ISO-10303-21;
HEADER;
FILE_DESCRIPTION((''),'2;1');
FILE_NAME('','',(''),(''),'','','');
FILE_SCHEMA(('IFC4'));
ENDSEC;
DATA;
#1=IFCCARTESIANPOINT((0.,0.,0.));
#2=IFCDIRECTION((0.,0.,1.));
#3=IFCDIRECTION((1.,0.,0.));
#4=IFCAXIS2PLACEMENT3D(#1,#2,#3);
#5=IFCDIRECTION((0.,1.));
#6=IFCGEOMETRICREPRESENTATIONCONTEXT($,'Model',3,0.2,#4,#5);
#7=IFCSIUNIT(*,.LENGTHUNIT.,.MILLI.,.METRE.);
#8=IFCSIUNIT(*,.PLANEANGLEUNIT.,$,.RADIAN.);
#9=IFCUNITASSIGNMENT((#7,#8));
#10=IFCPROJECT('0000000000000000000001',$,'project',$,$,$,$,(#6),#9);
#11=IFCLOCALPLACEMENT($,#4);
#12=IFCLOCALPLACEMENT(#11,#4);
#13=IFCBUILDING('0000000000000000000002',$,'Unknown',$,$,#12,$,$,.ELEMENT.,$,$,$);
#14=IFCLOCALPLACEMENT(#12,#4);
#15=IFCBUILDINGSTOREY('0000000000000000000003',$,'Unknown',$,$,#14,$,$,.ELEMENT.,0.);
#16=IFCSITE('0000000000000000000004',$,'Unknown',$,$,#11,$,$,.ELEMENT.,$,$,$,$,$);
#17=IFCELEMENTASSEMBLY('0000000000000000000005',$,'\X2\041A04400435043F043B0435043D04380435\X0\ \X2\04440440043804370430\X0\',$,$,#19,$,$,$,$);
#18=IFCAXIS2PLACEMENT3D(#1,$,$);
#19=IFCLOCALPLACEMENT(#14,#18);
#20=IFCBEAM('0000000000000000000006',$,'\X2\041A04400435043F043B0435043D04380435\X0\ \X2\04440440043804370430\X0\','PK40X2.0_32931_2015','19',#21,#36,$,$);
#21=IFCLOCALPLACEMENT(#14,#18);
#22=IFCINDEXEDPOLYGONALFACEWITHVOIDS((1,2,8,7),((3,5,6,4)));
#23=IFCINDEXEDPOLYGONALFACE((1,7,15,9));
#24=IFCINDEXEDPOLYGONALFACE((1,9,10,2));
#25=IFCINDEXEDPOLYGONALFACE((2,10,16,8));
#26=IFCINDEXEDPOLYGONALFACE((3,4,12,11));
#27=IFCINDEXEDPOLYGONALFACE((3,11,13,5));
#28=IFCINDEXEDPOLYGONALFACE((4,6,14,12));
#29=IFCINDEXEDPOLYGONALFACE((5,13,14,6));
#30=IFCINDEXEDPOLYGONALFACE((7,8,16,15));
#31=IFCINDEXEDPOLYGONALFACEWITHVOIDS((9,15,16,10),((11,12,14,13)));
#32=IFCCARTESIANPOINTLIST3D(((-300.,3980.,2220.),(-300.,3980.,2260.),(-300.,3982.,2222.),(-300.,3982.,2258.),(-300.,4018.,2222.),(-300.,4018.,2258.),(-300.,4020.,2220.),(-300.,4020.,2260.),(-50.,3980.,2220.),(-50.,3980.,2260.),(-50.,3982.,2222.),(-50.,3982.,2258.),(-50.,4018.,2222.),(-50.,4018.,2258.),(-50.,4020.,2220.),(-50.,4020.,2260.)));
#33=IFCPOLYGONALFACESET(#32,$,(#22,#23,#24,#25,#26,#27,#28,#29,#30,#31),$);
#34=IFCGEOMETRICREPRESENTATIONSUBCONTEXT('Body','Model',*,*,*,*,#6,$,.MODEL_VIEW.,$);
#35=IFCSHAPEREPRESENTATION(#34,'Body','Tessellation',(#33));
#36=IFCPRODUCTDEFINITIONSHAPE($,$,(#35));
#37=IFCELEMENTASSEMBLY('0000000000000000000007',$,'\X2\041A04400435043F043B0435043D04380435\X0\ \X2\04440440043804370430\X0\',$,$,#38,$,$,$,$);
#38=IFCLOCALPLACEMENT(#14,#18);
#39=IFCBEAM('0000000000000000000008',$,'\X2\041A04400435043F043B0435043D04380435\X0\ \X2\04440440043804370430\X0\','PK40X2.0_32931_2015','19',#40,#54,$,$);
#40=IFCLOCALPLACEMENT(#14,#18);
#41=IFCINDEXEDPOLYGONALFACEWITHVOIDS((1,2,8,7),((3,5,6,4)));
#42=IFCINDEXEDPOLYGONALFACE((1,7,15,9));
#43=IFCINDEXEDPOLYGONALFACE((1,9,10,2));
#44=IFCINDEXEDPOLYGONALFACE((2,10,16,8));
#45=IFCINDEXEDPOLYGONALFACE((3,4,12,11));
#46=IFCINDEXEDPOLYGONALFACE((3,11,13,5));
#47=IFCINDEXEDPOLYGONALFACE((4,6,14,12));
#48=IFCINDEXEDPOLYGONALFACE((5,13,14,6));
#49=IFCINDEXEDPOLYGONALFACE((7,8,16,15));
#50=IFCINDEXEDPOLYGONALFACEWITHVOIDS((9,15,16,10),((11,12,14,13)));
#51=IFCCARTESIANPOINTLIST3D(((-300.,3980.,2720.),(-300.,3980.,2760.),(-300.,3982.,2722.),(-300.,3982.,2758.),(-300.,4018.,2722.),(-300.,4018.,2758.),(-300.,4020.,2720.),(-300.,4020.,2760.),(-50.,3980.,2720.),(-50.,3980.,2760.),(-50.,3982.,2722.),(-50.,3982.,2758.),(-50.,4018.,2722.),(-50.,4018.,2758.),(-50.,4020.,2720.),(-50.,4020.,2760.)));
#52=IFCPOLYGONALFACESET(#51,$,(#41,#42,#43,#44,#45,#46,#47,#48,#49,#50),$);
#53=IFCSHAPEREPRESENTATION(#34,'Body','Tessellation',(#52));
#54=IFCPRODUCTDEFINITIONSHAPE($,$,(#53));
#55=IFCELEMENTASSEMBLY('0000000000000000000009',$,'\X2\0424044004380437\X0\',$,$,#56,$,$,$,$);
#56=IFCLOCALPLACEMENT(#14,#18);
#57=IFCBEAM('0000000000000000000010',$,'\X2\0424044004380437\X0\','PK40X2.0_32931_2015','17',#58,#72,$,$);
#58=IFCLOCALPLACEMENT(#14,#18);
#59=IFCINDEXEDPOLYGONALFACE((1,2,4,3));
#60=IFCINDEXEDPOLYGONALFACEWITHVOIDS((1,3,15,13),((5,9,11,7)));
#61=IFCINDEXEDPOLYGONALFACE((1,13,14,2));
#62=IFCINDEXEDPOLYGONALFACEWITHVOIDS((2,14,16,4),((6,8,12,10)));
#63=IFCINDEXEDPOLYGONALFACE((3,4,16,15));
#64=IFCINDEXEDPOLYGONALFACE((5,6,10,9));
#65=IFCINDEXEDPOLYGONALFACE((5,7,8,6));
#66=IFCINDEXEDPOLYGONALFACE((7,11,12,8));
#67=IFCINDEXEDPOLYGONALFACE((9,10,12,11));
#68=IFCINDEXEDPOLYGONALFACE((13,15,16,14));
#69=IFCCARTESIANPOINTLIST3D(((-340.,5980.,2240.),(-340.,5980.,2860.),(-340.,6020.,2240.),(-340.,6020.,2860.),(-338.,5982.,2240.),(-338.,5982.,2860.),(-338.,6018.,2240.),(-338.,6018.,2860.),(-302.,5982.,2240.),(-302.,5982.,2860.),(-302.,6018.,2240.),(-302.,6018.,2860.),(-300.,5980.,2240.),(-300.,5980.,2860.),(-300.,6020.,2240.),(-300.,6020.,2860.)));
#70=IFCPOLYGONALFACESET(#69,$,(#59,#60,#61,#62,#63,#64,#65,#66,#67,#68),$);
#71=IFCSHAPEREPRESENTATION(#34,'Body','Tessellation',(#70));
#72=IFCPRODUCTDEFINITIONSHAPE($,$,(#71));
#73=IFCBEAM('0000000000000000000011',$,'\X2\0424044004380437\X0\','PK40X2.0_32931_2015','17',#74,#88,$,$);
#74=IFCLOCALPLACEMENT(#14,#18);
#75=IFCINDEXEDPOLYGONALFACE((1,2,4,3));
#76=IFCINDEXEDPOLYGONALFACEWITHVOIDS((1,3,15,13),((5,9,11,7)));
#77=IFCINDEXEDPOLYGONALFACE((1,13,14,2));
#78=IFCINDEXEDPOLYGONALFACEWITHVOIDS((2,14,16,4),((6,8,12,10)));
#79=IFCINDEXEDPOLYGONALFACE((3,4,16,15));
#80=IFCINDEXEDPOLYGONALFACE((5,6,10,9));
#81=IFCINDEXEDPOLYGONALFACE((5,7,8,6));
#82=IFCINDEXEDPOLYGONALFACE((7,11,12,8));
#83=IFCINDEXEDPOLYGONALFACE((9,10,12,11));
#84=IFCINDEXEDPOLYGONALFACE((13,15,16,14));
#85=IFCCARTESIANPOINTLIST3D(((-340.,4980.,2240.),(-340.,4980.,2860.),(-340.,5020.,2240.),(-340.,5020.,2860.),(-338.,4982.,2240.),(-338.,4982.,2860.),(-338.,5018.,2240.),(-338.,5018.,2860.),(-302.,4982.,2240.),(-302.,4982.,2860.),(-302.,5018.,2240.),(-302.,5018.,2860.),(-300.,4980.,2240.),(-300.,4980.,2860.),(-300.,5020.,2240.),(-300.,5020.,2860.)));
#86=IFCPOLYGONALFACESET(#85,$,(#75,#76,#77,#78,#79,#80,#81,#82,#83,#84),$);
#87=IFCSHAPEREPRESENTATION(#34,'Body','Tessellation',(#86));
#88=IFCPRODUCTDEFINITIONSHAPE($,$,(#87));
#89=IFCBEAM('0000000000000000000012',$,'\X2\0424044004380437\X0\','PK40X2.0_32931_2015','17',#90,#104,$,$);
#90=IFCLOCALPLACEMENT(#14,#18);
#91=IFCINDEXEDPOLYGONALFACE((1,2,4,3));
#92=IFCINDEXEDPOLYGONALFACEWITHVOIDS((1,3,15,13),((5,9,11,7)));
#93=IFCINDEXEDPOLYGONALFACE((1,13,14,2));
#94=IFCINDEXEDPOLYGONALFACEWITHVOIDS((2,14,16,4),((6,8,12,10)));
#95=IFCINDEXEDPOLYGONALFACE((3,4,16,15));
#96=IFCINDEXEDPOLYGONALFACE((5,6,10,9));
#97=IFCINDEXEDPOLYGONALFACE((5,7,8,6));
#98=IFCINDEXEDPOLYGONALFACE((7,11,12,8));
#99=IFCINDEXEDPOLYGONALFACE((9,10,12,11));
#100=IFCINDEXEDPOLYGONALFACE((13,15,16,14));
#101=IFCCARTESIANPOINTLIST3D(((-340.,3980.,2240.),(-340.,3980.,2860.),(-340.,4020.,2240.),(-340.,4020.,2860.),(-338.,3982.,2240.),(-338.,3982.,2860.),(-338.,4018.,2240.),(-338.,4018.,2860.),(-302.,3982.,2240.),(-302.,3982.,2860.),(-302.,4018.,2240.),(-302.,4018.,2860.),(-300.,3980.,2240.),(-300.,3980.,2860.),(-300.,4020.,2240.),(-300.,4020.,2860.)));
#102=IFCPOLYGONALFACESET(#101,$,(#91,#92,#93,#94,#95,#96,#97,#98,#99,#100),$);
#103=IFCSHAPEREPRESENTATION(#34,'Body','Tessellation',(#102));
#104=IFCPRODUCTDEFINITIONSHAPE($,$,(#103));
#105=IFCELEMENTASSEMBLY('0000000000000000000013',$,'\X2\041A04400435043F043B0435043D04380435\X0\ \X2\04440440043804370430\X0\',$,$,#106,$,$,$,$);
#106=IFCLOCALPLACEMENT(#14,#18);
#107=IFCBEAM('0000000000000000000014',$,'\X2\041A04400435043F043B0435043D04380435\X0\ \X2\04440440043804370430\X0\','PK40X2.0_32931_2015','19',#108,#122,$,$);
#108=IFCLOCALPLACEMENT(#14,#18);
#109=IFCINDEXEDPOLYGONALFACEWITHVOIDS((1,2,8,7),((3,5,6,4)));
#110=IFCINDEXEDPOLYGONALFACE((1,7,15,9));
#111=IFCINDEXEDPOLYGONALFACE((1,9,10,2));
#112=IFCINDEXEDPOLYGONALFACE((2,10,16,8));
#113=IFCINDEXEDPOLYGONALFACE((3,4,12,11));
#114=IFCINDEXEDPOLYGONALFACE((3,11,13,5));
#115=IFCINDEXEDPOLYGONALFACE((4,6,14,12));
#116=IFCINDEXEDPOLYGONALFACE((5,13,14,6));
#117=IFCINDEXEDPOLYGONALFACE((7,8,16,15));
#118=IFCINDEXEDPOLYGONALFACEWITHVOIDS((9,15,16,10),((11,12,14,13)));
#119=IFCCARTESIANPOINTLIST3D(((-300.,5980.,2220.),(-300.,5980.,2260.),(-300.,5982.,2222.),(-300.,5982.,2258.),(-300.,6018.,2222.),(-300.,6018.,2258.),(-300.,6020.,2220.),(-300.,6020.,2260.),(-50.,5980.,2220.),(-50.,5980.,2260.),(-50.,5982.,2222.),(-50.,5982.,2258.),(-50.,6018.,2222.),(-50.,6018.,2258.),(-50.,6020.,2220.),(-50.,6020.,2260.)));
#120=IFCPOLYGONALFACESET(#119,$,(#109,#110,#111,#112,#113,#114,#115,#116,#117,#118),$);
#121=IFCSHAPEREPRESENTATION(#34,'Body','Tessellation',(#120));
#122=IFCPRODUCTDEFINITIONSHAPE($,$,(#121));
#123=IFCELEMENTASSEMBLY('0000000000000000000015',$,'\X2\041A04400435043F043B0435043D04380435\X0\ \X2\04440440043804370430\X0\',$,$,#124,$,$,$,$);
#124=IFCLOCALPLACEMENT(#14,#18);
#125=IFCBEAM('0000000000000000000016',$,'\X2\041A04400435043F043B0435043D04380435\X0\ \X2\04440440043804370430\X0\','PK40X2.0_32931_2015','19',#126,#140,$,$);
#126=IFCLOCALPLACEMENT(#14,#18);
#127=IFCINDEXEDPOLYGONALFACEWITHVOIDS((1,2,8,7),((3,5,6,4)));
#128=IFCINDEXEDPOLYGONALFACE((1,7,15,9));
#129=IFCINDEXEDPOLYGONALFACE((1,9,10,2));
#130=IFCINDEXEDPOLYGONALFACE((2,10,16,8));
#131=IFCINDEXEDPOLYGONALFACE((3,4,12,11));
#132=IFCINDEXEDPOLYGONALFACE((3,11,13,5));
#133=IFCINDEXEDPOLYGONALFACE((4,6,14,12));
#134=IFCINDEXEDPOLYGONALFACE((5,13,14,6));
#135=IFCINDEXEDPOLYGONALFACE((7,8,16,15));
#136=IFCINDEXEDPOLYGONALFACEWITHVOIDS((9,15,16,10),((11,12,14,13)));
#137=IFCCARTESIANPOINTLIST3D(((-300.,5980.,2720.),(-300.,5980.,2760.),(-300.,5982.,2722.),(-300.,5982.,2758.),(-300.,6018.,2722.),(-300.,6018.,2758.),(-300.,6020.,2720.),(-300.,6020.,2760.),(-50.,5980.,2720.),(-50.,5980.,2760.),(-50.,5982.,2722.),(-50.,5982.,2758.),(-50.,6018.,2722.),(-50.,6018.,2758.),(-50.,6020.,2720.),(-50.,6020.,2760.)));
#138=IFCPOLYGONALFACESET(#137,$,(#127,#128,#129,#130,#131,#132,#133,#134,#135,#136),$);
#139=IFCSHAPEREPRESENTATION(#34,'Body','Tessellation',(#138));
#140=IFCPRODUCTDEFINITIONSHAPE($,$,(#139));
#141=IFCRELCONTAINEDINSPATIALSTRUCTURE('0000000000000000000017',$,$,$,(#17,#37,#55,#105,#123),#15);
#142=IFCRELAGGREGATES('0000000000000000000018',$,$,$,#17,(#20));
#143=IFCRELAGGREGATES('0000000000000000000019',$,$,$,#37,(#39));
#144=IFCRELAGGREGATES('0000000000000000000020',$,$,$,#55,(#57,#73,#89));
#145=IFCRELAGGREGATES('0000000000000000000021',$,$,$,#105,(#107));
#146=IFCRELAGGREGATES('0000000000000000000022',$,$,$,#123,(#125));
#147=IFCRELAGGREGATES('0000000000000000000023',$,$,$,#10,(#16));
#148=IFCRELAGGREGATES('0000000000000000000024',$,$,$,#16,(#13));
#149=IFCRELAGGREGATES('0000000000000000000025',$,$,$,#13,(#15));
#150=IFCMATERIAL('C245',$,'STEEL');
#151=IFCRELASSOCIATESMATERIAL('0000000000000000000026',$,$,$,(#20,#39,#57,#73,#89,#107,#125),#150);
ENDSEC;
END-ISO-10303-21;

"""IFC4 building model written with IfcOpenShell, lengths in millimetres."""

from ifc_helpers import new_model, si_unit, direction, frame, origin_with_axes, place, context, subcontext, project, spatial, line, indexed_curve, outline, extrude, material, element, aggregate, save


model = new_model("IFC4")

# Units and contexts
model_context = context("Model", 3, precision=0.2, world=origin_with_axes(), true_north=direction((0.0, 1.0)))
body_context = subcontext(model_context, "Body", "Model", "MODEL_VIEW")
ifc_project = project(units=[si_unit("LENGTHUNIT", "METRE", prefix="MILLI"), si_unit("PLANEANGLEUNIT", "RADIAN")], contexts=[model_context])

# Site, building, storey
site_placement = place(None, origin_with_axes())
site = spatial("IfcSite", under=ifc_project, at=site_placement, Name="Unknown", CompositionType="ELEMENT")
building_placement = place(site_placement, origin_with_axes())
building = spatial("IfcBuilding", under=site, at=building_placement, Name="Unknown", CompositionType="ELEMENT")
storey_placement = place(building_placement, origin_with_axes())
storey = spatial("IfcBuildingStorey", under=building, at=storey_placement, Name="Unknown", CompositionType="ELEMENT", Elevation=0.0)

# Shared definitions
ifc_material_1 = material(Name="C245", Category="STEEL")

# Element assemblies, beams
assembly_1_placement = place(storey_placement, frame((-300.0, 4000.0, 2240.0), z_axis=(0.0, 1.0, 0.0), x_axis=(1.0, 0.0, 0.0)))
assembly_1 = element("IfcElementAssembly", 1, at=assembly_1_placement, inside=storey, Name="Крепление фриза")
beam_1_placement = place(assembly_1_placement, origin_with_axes())
beam_1 = element("IfcBeam", 2, at=beam_1_placement, material=ifc_material_1, Name="Крепление фриза", Description="PK40X2.0_32931_2015", ObjectType="19", context=body_context, shape_type="SolidModel", body=[
    extrude(outline(indexed_curve([(-20.0, -20.0), (20.0, -20.0), (20.0, 20.0), (-20.0, 20.0)], segments=[line(1, 2, 3, 4, 1)]), holes=[indexed_curve([(-18.0, -18.0), (-18.0, 18.0), (18.0, 18.0), (18.0, -18.0)], segments=[line(1, 2, 3, 4, 1)])]), frame((0.0, 0.0, 0.0), z_axis=(-1.0, 0.0, 0.0), x_axis=(0.0, 0.0, 1.0)), (0.0, 0.0, -1.0), 250.0),
])
aggregate(assembly_1, [beam_1])
assembly_2_placement = place(storey_placement, frame((-300.0, 4000.0, 2740.0), z_axis=(0.0, 1.0, 0.0), x_axis=(1.0, 0.0, 0.0)))
assembly_2 = element("IfcElementAssembly", 3, at=assembly_2_placement, inside=storey, Name="Крепление фриза")
beam_2_placement = place(assembly_2_placement, origin_with_axes())
beam_2 = element("IfcBeam", 4, at=beam_2_placement, material=ifc_material_1, Name="Крепление фриза", Description="PK40X2.0_32931_2015", ObjectType="19", context=body_context, shape_type="SolidModel", body=[
    extrude(outline(indexed_curve([(-20.0, -20.0), (20.0, -20.0), (20.0, 20.0), (-20.0, 20.0)], segments=[line(1, 2, 3, 4, 1)]), holes=[indexed_curve([(-18.0, -18.0), (-18.0, 18.0), (18.0, 18.0), (18.0, -18.0)], segments=[line(1, 2, 3, 4, 1)])]), frame((0.0, 0.0, 0.0), z_axis=(-1.0, 0.0, 0.0), x_axis=(0.0, 0.0, 1.0)), (0.0, 0.0, -1.0), 250.0),
])
aggregate(assembly_2, [beam_2])

# Element assembly, beams
assembly_3_placement = place(storey_placement, frame((-320.0, -300.0, 2880.0), z_axis=(1.0, 0.0, 0.0), x_axis=(0.0, 1.0, 0.0)))
assembly_3 = element("IfcElementAssembly", 5, at=assembly_3_placement, inside=storey, Name="Фриз")
beam_3_placement = place(assembly_3_placement, frame((6300.0, -20.0, 0.0), z_axis=(-1.0, 0.0, 0.0), x_axis=(0.0, -1.0, 0.0)))
beam_3 = element("IfcBeam", 6, at=beam_3_placement, material=ifc_material_1, Name="Фриз", Description="PK40X2.0_32931_2015", ObjectType="17", context=body_context, shape_type="SolidModel", body=[
    extrude(outline(indexed_curve([(-20.0, -20.0), (20.0, -20.0), (20.0, 20.0), (-20.0, 20.0)], segments=[line(1, 2, 3, 4, 1)]), holes=[indexed_curve([(-18.0, -18.0), (-18.0, 18.0), (18.0, 18.0), (18.0, -18.0)], segments=[line(1, 2, 3, 4, 1)])]), frame((0.0, 0.0, 0.0), z_axis=(-1.0, 0.0, 0.0), x_axis=(0.0, 0.0, 1.0)), (0.0, 0.0, -1.0), 620.0),
])
beam_4_placement = place(assembly_3_placement, frame((5300.0, -20.0, 0.0), z_axis=(-1.0, 0.0, 0.0), x_axis=(0.0, -1.0, 0.0)))
beam_4 = element("IfcBeam", 7, at=beam_4_placement, material=ifc_material_1, Name="Фриз", Description="PK40X2.0_32931_2015", ObjectType="17", context=body_context, shape_type="SolidModel", body=[
    extrude(outline(indexed_curve([(-20.0, -20.0), (20.0, -20.0), (20.0, 20.0), (-20.0, 20.0)], segments=[line(1, 2, 3, 4, 1)]), holes=[indexed_curve([(-18.0, -18.0), (-18.0, 18.0), (18.0, 18.0), (18.0, -18.0)], segments=[line(1, 2, 3, 4, 1)])]), frame((0.0, 0.0, 0.0), z_axis=(-1.0, 0.0, 0.0), x_axis=(0.0, 0.0, 1.0)), (0.0, 0.0, -1.0), 620.0),
])
beam_5_placement = place(assembly_3_placement, frame((4300.0, -20.0, 0.0), z_axis=(-1.0, 0.0, 0.0), x_axis=(0.0, -1.0, 0.0)))
beam_5 = element("IfcBeam", 8, at=beam_5_placement, material=ifc_material_1, Name="Фриз", Description="PK40X2.0_32931_2015", ObjectType="17", context=body_context, shape_type="SolidModel", body=[
    extrude(outline(indexed_curve([(-20.0, -20.0), (20.0, -20.0), (20.0, 20.0), (-20.0, 20.0)], segments=[line(1, 2, 3, 4, 1)]), holes=[indexed_curve([(-18.0, -18.0), (-18.0, 18.0), (18.0, 18.0), (18.0, -18.0)], segments=[line(1, 2, 3, 4, 1)])]), frame((0.0, 0.0, 0.0), z_axis=(-1.0, 0.0, 0.0), x_axis=(0.0, 0.0, 1.0)), (0.0, 0.0, -1.0), 620.0),
])
aggregate(assembly_3, [beam_3, beam_4, beam_5])

# Element assemblies, beams
assembly_4_placement = place(storey_placement, frame((-300.0, 6000.0, 2240.0), z_axis=(0.0, 1.0, 0.0), x_axis=(1.0, 0.0, 0.0)))
assembly_4 = element("IfcElementAssembly", 9, at=assembly_4_placement, inside=storey, Name="Крепление фриза")
beam_6_placement = place(assembly_4_placement, origin_with_axes())
beam_6 = element("IfcBeam", 10, at=beam_6_placement, material=ifc_material_1, Name="Крепление фриза", Description="PK40X2.0_32931_2015", ObjectType="19", context=body_context, shape_type="SolidModel", body=[
    extrude(outline(indexed_curve([(-20.0, -20.0), (20.0, -20.0), (20.0, 20.0), (-20.0, 20.0)], segments=[line(1, 2, 3, 4, 1)]), holes=[indexed_curve([(-18.0, -18.0), (-18.0, 18.0), (18.0, 18.0), (18.0, -18.0)], segments=[line(1, 2, 3, 4, 1)])]), frame((0.0, 0.0, 0.0), z_axis=(-1.0, 0.0, 0.0), x_axis=(0.0, 0.0, 1.0)), (0.0, 0.0, -1.0), 250.0),
])
aggregate(assembly_4, [beam_6])
assembly_5_placement = place(storey_placement, frame((-300.0, 6000.0, 2740.0), z_axis=(0.0, 1.0, 0.0), x_axis=(1.0, 0.0, 0.0)))
assembly_5 = element("IfcElementAssembly", 11, at=assembly_5_placement, inside=storey, Name="Крепление фриза")
beam_7_placement = place(assembly_5_placement, origin_with_axes())
beam_7 = element("IfcBeam", 12, at=beam_7_placement, material=ifc_material_1, Name="Крепление фриза", Description="PK40X2.0_32931_2015", ObjectType="19", context=body_context, shape_type="SolidModel", body=[
    extrude(outline(indexed_curve([(-20.0, -20.0), (20.0, -20.0), (20.0, 20.0), (-20.0, 20.0)], segments=[line(1, 2, 3, 4, 1)]), holes=[indexed_curve([(-18.0, -18.0), (-18.0, 18.0), (18.0, 18.0), (18.0, -18.0)], segments=[line(1, 2, 3, 4, 1)])]), frame((0.0, 0.0, 0.0), z_axis=(-1.0, 0.0, 0.0), x_axis=(0.0, 0.0, 1.0)), (0.0, 0.0, -1.0), 250.0),
])
aggregate(assembly_5, [beam_7])

save(model, "model.ifc")
